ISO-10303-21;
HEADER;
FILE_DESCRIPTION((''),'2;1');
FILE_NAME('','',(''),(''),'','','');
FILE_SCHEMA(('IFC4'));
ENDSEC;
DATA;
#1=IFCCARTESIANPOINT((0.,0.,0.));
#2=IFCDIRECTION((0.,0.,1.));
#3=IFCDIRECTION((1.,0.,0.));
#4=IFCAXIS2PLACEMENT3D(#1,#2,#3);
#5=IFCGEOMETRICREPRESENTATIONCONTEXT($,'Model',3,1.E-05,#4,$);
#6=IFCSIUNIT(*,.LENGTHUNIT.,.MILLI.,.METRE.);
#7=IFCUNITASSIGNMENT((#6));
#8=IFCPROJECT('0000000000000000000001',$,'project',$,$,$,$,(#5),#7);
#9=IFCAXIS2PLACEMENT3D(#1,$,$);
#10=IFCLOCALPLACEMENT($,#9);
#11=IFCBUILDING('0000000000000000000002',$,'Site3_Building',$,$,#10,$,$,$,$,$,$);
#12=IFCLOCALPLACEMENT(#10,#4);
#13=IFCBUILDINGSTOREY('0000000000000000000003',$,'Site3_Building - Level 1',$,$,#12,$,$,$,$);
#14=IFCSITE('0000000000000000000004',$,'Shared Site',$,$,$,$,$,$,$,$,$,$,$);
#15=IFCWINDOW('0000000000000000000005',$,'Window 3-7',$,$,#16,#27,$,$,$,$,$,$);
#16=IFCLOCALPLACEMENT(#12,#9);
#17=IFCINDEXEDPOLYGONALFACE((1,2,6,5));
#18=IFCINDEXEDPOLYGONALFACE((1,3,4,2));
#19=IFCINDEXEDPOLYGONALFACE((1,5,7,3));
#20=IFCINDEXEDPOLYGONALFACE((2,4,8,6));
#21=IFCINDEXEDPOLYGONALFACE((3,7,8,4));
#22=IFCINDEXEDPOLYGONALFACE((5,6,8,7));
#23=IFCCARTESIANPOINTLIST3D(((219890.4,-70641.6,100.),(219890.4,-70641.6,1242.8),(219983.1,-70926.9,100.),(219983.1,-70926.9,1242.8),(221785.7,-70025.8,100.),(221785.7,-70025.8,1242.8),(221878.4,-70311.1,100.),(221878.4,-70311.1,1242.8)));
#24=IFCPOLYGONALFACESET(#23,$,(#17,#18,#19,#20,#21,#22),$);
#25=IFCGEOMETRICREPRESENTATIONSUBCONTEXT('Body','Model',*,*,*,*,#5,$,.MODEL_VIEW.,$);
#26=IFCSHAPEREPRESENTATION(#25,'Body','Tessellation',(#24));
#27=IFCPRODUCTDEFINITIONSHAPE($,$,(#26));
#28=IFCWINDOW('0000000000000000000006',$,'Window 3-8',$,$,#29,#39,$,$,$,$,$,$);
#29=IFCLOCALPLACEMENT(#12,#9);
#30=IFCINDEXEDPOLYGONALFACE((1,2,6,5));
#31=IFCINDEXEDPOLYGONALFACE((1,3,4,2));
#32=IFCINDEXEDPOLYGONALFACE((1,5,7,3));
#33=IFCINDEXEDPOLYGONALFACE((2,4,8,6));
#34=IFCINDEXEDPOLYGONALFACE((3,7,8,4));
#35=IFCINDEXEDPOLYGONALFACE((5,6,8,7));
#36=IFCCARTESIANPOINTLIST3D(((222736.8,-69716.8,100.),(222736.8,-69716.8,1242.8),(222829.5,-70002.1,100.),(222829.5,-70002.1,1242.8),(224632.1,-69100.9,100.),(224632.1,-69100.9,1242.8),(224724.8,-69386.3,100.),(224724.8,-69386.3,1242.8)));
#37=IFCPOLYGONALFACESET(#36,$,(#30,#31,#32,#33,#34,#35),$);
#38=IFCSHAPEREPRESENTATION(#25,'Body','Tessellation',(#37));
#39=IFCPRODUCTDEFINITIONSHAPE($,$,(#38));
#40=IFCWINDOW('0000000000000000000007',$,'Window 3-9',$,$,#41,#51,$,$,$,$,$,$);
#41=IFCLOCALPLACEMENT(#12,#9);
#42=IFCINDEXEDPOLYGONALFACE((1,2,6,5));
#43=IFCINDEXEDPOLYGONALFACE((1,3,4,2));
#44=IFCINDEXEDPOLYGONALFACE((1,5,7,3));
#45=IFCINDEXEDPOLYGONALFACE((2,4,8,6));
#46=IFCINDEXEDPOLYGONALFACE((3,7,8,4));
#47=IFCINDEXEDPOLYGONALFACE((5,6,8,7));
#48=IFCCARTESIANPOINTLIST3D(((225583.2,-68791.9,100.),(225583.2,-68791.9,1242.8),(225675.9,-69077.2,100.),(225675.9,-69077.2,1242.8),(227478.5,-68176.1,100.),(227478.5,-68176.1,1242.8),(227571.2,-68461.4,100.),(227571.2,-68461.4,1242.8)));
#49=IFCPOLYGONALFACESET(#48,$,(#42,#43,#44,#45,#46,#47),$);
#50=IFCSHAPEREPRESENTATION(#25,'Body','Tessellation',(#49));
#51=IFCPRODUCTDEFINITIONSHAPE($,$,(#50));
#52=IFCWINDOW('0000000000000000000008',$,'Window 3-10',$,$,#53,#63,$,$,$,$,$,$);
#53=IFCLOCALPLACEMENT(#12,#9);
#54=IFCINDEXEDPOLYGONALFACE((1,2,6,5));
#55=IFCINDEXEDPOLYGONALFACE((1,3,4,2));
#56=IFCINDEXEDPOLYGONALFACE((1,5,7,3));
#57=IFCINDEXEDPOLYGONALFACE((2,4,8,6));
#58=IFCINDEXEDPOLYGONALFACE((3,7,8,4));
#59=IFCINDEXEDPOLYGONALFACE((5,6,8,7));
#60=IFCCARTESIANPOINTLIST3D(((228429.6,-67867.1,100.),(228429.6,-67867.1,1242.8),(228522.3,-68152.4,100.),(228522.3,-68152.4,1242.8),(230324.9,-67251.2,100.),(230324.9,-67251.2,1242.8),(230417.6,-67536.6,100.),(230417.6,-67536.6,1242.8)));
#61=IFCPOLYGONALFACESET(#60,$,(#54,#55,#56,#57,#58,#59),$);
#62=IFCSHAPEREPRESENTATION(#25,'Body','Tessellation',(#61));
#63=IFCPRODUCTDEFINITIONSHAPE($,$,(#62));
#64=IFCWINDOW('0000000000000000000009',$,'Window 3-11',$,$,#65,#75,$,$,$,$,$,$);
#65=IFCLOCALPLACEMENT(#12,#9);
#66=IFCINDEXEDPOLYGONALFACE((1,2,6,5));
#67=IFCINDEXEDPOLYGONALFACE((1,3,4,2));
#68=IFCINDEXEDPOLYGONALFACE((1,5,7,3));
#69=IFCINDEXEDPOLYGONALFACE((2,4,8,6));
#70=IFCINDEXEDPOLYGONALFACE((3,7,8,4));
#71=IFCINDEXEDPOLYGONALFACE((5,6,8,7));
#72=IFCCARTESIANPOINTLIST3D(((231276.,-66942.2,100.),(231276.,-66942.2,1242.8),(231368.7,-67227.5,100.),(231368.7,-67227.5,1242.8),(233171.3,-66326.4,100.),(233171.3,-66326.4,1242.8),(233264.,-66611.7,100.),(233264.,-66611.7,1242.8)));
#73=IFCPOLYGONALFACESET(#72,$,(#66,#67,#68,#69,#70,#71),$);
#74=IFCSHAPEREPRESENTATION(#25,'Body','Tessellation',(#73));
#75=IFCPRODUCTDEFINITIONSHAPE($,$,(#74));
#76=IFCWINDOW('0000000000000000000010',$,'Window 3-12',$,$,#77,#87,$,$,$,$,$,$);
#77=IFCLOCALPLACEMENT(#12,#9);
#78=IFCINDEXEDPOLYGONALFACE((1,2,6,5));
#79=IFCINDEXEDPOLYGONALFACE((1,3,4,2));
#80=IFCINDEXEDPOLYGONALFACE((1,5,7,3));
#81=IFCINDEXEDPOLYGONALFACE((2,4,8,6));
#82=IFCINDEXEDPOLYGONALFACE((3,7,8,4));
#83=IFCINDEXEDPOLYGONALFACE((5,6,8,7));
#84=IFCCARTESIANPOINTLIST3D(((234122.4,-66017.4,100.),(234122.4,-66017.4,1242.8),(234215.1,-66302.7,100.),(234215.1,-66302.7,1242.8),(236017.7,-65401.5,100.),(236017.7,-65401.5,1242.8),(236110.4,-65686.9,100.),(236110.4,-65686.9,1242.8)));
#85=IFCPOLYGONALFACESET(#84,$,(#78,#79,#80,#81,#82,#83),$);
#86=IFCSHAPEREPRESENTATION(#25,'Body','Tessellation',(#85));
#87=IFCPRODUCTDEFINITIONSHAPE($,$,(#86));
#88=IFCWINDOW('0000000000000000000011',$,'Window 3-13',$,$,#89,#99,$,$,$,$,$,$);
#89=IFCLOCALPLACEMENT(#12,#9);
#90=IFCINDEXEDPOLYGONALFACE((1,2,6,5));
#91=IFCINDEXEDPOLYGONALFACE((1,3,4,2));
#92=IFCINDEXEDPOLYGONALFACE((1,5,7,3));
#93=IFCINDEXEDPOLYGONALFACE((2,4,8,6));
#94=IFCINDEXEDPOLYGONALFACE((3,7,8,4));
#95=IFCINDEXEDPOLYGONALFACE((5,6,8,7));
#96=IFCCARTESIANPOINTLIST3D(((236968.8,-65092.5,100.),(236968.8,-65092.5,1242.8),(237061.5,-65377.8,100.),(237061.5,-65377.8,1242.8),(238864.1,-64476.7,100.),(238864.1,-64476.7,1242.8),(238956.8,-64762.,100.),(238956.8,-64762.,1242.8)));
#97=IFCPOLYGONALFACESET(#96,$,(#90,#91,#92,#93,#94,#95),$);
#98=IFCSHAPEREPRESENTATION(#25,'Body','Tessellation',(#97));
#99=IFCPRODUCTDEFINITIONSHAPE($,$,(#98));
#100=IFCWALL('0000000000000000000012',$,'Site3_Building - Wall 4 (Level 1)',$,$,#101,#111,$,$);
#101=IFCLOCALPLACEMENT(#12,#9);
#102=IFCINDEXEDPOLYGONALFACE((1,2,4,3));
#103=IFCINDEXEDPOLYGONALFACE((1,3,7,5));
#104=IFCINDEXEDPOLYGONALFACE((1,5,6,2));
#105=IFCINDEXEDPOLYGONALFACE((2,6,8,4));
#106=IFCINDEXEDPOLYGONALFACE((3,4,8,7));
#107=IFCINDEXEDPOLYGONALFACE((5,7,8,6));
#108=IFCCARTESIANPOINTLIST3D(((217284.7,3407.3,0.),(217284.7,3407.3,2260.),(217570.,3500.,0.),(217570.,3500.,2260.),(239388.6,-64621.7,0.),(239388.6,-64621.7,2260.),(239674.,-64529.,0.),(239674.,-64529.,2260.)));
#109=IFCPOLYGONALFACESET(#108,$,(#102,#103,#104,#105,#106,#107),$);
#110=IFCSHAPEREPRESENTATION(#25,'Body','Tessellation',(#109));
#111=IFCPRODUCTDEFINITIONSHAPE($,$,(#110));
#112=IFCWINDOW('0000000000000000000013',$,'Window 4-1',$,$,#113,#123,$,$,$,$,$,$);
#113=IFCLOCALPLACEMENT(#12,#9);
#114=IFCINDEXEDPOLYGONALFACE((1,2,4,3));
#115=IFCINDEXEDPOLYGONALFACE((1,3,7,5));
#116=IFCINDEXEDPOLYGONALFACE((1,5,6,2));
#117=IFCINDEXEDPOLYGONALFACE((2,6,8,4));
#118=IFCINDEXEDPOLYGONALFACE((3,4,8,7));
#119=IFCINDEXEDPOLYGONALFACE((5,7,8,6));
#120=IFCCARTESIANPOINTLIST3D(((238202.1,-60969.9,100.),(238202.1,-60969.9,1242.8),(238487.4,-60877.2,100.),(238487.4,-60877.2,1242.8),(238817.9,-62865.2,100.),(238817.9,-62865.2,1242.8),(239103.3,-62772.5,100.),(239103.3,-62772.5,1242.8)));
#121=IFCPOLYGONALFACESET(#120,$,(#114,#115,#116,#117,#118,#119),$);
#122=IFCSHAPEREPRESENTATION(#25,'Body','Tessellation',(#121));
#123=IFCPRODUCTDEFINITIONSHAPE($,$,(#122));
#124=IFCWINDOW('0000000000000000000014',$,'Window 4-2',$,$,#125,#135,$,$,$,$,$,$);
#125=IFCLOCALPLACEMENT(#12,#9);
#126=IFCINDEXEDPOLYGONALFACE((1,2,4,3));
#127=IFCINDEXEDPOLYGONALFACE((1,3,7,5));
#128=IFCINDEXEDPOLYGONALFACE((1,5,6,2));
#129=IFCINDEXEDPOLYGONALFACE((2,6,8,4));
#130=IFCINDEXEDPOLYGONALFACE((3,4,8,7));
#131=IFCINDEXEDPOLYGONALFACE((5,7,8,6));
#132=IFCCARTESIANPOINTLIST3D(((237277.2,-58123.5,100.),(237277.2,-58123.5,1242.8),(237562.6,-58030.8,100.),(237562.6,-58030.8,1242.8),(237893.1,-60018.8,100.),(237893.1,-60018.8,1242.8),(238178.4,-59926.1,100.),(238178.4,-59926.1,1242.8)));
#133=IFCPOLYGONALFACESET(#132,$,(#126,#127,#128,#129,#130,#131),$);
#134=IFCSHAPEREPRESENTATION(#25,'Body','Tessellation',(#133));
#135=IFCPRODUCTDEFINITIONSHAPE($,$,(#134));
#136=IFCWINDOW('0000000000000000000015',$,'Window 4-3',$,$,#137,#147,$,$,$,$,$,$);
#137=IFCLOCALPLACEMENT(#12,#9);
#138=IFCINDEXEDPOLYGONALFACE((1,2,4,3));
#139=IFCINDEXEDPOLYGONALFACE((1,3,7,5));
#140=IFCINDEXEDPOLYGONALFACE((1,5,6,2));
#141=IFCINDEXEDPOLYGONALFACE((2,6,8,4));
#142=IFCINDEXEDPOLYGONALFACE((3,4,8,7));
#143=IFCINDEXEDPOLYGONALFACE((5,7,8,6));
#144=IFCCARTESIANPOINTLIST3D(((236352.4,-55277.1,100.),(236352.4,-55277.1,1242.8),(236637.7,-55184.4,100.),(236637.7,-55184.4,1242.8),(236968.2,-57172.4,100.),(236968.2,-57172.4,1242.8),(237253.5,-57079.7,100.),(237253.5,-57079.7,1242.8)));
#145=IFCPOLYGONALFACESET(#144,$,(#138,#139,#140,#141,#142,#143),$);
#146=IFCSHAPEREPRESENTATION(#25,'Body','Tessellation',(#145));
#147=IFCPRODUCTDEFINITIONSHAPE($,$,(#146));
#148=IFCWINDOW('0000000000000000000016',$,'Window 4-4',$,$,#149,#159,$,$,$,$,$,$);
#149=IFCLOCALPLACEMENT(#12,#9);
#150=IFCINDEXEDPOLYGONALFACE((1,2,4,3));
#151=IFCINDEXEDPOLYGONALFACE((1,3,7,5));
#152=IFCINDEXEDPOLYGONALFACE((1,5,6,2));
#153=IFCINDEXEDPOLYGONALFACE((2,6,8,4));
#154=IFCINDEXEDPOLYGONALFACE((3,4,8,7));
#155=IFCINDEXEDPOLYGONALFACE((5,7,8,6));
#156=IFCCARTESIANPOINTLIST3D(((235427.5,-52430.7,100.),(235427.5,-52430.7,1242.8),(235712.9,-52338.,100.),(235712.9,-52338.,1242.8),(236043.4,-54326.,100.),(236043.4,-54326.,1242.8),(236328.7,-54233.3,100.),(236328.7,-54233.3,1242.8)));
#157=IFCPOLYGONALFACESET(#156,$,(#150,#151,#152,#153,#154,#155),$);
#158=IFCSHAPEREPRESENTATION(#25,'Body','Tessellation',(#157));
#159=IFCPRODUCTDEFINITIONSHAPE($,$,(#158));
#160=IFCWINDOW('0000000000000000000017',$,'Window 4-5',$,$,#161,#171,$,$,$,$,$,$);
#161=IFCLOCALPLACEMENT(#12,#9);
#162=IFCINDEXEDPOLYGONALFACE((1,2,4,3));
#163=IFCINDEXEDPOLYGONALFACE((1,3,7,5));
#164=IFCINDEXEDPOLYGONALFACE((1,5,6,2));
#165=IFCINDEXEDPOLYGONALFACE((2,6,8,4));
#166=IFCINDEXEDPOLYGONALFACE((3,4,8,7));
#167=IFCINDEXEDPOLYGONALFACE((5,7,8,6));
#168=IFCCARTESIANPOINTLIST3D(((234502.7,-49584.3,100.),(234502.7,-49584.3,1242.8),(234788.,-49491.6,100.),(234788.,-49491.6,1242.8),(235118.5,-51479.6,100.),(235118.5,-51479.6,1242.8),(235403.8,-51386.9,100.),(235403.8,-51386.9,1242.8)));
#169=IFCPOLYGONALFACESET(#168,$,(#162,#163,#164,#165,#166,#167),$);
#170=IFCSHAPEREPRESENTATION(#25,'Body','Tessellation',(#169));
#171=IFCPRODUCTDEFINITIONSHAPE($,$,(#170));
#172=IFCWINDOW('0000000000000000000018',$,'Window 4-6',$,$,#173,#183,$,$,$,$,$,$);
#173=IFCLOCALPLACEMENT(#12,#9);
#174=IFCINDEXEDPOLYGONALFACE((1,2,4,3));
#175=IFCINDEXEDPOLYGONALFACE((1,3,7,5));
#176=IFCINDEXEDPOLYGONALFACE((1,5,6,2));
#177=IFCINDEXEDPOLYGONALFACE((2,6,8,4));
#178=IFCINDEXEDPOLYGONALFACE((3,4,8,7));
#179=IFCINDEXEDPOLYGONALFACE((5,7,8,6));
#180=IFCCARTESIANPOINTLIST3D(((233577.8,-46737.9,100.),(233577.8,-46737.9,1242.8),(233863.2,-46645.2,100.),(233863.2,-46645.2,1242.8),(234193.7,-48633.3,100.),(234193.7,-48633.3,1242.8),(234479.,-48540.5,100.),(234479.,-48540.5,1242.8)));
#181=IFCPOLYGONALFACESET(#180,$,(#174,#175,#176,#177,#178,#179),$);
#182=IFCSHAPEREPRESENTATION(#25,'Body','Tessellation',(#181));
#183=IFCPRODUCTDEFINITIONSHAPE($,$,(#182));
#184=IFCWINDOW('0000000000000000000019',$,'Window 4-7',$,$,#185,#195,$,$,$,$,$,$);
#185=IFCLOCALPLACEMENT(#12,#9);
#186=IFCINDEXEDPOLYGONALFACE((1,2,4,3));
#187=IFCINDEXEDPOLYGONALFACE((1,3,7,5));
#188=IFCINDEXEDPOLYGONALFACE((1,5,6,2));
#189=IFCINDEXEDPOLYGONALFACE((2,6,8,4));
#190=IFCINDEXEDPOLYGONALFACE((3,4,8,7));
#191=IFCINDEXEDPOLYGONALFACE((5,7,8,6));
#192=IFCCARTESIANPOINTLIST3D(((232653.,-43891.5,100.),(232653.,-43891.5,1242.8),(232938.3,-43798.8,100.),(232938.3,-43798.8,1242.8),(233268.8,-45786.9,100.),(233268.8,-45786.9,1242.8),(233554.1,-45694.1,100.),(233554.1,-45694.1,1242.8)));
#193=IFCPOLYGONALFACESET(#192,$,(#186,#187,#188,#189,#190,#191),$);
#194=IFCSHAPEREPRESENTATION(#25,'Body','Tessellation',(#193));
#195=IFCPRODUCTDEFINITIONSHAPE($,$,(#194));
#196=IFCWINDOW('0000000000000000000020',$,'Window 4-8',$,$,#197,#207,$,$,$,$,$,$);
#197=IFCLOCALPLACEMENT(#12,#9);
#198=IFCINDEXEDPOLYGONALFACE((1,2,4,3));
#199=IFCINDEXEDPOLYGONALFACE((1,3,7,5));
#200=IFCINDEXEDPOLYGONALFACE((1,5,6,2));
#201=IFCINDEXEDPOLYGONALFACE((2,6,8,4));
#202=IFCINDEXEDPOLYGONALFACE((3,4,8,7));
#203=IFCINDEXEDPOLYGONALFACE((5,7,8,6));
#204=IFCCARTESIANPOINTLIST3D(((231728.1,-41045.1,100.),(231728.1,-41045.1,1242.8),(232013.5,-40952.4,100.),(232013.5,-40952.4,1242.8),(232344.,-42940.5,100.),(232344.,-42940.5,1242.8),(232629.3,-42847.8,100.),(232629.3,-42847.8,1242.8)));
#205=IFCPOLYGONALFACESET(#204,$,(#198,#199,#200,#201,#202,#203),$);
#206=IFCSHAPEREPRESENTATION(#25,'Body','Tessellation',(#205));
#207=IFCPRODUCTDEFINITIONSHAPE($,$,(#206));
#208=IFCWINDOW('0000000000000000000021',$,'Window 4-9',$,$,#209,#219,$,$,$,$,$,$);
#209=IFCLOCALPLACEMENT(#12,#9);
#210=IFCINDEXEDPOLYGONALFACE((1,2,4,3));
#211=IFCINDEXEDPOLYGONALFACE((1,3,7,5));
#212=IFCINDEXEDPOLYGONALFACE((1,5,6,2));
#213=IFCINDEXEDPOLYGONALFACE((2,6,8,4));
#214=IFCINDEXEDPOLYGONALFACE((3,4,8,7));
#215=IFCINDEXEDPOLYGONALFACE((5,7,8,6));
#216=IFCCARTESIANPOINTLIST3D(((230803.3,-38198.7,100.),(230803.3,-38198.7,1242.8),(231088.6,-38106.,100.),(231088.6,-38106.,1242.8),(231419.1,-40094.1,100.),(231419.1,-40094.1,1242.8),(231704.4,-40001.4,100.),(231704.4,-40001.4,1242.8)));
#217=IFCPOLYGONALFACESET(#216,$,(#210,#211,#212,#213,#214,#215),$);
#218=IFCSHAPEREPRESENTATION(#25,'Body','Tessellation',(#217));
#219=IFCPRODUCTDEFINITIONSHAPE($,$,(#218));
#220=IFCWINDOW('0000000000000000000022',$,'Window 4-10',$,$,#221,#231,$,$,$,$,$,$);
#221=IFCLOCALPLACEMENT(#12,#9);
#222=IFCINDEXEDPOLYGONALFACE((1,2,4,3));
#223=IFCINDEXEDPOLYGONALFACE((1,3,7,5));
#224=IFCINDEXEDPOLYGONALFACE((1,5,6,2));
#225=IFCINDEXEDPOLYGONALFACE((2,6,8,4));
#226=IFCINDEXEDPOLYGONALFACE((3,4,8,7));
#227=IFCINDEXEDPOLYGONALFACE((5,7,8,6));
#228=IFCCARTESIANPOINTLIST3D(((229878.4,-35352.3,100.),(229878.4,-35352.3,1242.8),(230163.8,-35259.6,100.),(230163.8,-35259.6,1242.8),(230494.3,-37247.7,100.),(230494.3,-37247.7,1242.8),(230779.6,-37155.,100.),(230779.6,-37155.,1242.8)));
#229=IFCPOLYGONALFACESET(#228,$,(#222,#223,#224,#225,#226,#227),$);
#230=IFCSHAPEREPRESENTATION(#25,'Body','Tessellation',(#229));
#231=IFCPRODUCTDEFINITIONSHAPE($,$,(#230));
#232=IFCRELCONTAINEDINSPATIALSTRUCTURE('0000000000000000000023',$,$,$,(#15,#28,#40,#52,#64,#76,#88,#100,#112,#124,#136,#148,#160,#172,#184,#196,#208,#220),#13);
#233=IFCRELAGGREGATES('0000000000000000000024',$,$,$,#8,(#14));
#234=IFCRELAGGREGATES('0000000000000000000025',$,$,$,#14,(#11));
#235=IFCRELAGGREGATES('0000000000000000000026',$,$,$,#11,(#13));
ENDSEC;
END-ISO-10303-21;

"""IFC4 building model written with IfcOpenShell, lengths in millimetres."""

from ifc_helpers import new_model, si_unit, frame, origin, origin_with_axes, place, context, subcontext, project, spatial, indexed_curve, outline, extrude, element, save


model = new_model("IFC4")

# Units and contexts
model_context = context("Model", 3, precision=1e-05, world=origin_with_axes())
body_context = subcontext(model_context, "Body", "Model", "MODEL_VIEW")
ifc_project = project(units=[si_unit("LENGTHUNIT", "METRE", prefix="MILLI")], contexts=[model_context])

# Site, building, storey
site = spatial("IfcSite", under=ifc_project, Name="Shared Site")
building_placement = place(None, origin())
building = spatial("IfcBuilding", under=site, at=building_placement, Name="Site3_Building")
storey_placement = place(building_placement, origin_with_axes())
storey = spatial("IfcBuildingStorey", under=building, at=storey_placement, Name="Site3_Building - Level 1")

# Windows
for number, where, z_axis, x_axis, name in (
    (1, (219983.1, -70926.9, 100.0), (0.0, 0.0, 1.0), (0.951057, 0.309017, 0.0), "Window 3-7"),
    (2, (222829.5, -70002.1, 100.0), (0.0, 0.0, 1.0), (0.951057, 0.309017, 0.0), "Window 3-8"),
    (3, (225675.9, -69077.2, 100.0), (0.0, 0.0, 1.0), (0.951057, 0.309017, 0.0), "Window 3-9"),
    (4, (228522.3, -68152.4, 100.0), (0.0, 0.0, 1.0), (0.951057, 0.309017, 0.0), "Window 3-10"),
    (5, (231368.7, -67227.5, 100.0), (0.0, 0.0, 1.0), (0.951057, 0.309017, 0.0), "Window 3-11"),
    (6, (234215.1, -66302.7, 100.0), (0.0, 0.0, 1.0), (0.951057, 0.309017, 0.0), "Window 3-12"),
    (7, (237061.5, -65377.8, 100.0), (0.0, 0.0, 1.0), (0.951057, 0.309017, 0.0), "Window 3-13"),
):
    element("IfcWindow", number, at=place(storey_placement, frame(where, z_axis=z_axis, x_axis=x_axis)), inside=storey, Name=name, context=body_context, shape_type="SweptSolid", body=[
        extrude(outline(indexed_curve([(0.0, 0.0), (0.0, 300.0), (1992.9, 300.0), (1992.9, 0.0), (0.0, 0.0)], self_intersect=False)), origin_with_axes(), (0.0, 0.0, 1.0), 1142.8),
    ])

# Wall
wall_1_placement = place(storey_placement, frame((239674.0, -64529.0, 0.0), z_axis=(0.0, 0.0, 1.0), x_axis=(-0.309017, 0.951057, 0.0)))
element("IfcWall", 8, at=wall_1_placement, inside=storey, Name="Site3_Building - Wall 4 (Level 1)", context=body_context, shape_type="SweptSolid", body=[
    extrude(outline(indexed_curve([(0.0, 0.0), (0.0, 300.0), (71529.9, 300.0), (71529.9, 0.0), (0.0, 0.0)], self_intersect=False)), origin_with_axes(), (0.0, 0.0, 1.0), 2260.0),
])

# Windows
for number, where, z_axis, x_axis, name in (
    (9, (239103.3, -62772.5, 100.0), (0.0, 0.0, 1.0), (-0.309017, 0.951057, 0.0), "Window 4-1"),
    (10, (238178.4, -59926.1, 100.0), (0.0, 0.0, 1.0), (-0.309017, 0.951057, 0.0), "Window 4-2"),
    (11, (237253.5, -57079.7, 100.0), (0.0, 0.0, 1.0), (-0.309017, 0.951057, 0.0), "Window 4-3"),
    (12, (236328.7, -54233.3, 100.0), (0.0, 0.0, 1.0), (-0.309017, 0.951057, 0.0), "Window 4-4"),
    (13, (235403.8, -51386.9, 100.0), (0.0, 0.0, 1.0), (-0.309017, 0.951057, 0.0), "Window 4-5"),
    (14, (234479.0, -48540.5, 100.0), (0.0, 0.0, 1.0), (-0.309017, 0.951057, 0.0), "Window 4-6"),
    (15, (233554.1, -45694.1, 100.0), (0.0, 0.0, 1.0), (-0.309017, 0.951057, 0.0), "Window 4-7"),
    (16, (232629.3, -42847.8, 100.0), (0.0, 0.0, 1.0), (-0.309017, 0.951057, 0.0), "Window 4-8"),
    (17, (231704.4, -40001.4, 100.0), (0.0, 0.0, 1.0), (-0.309017, 0.951057, 0.0), "Window 4-9"),
    (18, (230779.6, -37155.0, 100.0), (0.0, 0.0, 1.0), (-0.309017, 0.951057, 0.0), "Window 4-10"),
):
    element("IfcWindow", number, at=place(storey_placement, frame(where, z_axis=z_axis, x_axis=x_axis)), inside=storey, Name=name, context=body_context, shape_type="SweptSolid", body=[
        extrude(outline(indexed_curve([(0.0, 0.0), (0.0, 300.0), (1992.9, 300.0), (1992.9, 0.0), (0.0, 0.0)], self_intersect=False)), origin_with_axes(), (0.0, 0.0, 1.0), 1142.8),
    ])

save(model, "model.ifc")
